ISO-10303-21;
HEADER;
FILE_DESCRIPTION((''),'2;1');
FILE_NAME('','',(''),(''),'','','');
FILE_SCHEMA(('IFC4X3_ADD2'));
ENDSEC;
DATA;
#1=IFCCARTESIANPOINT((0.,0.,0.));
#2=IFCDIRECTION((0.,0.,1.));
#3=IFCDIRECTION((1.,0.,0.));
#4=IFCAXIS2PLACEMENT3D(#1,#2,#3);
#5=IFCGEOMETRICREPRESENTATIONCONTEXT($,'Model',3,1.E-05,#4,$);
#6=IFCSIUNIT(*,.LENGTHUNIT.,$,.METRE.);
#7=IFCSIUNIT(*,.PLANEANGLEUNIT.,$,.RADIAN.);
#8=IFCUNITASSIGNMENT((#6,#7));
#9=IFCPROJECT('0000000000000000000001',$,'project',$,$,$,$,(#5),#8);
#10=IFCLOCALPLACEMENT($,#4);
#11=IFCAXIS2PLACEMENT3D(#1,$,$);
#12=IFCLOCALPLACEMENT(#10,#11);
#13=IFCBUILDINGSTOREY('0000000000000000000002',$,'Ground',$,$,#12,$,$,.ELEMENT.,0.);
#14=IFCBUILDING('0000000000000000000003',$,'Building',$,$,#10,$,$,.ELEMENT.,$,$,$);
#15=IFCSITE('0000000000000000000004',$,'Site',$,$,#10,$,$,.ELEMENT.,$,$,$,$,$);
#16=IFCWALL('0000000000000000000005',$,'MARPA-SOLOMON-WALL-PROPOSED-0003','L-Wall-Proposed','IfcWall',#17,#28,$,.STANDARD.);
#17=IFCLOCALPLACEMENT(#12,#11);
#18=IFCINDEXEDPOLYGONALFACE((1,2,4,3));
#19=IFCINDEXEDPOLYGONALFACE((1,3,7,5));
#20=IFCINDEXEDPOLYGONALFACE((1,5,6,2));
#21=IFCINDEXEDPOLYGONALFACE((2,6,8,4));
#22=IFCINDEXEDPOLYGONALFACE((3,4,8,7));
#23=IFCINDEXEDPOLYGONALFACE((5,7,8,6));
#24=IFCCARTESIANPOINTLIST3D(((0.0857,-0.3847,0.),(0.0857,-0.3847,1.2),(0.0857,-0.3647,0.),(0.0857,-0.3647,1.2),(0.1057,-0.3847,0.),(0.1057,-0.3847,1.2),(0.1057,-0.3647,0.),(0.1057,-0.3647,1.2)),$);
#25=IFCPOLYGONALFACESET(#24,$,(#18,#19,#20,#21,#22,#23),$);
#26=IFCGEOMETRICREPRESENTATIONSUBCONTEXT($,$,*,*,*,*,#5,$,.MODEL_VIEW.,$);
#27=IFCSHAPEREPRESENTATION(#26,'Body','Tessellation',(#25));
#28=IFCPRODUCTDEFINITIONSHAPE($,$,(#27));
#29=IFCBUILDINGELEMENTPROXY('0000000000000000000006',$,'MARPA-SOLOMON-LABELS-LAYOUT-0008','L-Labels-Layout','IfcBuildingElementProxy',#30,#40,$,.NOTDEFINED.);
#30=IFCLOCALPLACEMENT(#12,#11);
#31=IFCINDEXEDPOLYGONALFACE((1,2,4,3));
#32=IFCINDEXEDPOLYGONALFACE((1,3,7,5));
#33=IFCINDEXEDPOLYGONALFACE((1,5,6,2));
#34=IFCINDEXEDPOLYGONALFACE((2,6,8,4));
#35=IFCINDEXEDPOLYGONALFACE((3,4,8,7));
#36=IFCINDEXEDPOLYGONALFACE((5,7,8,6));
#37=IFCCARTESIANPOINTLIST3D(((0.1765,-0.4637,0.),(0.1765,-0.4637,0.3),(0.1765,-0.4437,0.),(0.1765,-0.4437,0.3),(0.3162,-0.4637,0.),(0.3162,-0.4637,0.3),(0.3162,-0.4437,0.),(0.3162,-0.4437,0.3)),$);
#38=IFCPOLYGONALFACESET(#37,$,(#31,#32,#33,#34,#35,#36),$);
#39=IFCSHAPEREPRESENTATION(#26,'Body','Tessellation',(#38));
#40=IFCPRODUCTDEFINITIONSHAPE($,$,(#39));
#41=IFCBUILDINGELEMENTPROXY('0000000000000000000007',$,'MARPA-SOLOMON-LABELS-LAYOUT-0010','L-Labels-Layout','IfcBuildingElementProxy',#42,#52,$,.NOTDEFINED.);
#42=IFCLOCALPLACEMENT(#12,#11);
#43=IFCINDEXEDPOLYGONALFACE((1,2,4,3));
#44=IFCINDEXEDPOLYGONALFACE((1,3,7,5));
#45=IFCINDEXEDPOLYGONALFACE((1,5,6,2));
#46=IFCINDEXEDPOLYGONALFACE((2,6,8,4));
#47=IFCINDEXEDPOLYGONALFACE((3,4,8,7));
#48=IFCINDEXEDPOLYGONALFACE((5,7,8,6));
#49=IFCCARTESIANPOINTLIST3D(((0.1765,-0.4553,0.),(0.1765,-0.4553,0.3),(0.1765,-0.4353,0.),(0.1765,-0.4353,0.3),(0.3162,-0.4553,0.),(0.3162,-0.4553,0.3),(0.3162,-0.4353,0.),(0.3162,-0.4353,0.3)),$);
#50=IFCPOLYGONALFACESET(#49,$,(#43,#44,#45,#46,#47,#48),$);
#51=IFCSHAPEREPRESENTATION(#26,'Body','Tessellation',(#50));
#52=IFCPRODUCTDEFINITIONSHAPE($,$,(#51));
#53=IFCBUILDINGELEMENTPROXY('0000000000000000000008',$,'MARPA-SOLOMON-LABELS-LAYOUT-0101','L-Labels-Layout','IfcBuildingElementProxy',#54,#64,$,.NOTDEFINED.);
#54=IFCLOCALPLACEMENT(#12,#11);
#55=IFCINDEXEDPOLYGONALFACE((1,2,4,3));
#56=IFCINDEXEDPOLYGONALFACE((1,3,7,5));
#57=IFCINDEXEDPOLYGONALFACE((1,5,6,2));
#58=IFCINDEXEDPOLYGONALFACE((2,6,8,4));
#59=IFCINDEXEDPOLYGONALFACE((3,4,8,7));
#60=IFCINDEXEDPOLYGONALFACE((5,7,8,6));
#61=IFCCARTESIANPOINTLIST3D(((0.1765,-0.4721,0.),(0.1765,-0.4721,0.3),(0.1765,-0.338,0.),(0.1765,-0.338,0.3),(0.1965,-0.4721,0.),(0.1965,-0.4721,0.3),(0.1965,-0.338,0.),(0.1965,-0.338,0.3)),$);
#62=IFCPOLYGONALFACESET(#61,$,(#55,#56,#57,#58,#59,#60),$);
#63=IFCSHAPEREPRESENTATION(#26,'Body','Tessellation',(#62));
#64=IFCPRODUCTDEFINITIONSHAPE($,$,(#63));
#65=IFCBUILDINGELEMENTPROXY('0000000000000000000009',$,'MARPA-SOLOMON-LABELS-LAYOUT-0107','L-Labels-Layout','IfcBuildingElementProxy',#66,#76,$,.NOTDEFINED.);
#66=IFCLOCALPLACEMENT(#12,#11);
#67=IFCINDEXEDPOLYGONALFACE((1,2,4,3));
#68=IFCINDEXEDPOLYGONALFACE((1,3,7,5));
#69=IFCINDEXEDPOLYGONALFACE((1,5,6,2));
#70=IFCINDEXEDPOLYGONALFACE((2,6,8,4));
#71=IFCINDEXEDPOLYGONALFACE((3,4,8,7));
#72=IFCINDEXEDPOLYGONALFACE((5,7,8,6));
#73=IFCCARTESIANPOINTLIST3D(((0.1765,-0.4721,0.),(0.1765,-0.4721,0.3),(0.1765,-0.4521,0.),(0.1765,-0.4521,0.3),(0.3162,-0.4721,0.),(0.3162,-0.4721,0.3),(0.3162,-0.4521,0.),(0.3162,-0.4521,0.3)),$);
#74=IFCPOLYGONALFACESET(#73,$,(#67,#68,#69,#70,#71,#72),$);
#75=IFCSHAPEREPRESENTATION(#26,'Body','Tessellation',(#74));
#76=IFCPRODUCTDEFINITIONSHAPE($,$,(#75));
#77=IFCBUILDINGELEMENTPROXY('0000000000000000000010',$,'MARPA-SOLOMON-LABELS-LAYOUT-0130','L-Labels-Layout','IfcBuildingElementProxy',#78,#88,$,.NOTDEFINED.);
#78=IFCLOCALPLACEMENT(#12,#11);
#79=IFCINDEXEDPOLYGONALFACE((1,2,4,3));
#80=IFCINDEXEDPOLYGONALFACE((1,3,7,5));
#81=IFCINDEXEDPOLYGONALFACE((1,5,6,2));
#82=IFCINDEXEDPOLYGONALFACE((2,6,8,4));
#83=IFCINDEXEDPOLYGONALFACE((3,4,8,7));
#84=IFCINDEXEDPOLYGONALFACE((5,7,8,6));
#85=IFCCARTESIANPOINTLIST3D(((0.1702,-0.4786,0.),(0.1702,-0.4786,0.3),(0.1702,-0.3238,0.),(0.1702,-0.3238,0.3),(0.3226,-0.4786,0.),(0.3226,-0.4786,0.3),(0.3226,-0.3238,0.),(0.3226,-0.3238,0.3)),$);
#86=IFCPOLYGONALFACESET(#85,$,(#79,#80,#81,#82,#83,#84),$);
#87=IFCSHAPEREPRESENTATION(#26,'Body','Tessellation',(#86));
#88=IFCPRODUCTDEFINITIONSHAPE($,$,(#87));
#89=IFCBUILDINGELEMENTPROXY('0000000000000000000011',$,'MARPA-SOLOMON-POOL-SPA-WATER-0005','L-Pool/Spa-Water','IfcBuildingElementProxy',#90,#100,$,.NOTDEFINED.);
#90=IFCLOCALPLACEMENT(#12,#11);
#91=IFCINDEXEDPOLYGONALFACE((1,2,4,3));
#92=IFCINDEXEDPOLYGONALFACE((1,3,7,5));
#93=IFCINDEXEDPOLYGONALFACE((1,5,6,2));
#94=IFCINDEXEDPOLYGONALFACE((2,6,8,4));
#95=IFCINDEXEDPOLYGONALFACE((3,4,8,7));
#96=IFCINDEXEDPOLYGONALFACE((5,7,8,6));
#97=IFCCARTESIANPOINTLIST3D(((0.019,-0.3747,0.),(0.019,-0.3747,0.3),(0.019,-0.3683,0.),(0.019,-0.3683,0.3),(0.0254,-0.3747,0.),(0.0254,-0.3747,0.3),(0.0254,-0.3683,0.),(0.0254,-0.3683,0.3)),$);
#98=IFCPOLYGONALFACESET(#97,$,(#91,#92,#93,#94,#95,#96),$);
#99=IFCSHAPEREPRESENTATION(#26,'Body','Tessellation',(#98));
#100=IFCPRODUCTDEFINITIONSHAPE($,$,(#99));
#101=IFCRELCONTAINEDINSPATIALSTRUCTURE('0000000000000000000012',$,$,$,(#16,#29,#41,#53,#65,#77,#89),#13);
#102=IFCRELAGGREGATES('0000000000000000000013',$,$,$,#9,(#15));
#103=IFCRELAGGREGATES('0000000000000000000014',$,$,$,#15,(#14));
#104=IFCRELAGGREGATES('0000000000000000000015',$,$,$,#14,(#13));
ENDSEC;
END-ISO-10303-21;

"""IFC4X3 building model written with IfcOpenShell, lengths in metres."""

from ifc_helpers import new_model, si_unit, frame, frame_2d, origin, origin_with_axes, place, context, subcontext, project, spatial, polyline, rectangle, outline, extrude, element, save


model = new_model("IFC4X3")

# Units and contexts
model_context = context("Model", 3, precision=1e-05, world=origin_with_axes())
sub_context = subcontext(model_context, None, None, "MODEL_VIEW")
ifc_project = project(units=[si_unit("LENGTHUNIT", "METRE"), si_unit("PLANEANGLEUNIT", "RADIAN")], contexts=[model_context])

# Site, building, storey
placement = place(None, origin_with_axes())
site = spatial("IfcSite", under=ifc_project, at=placement, Name="Site", CompositionType="ELEMENT")
building = spatial("IfcBuilding", under=site, at=placement, Name="Building", CompositionType="ELEMENT")
storey_placement = place(placement, origin())
storey = spatial("IfcBuildingStorey", under=building, at=storey_placement, Name="Ground", CompositionType="ELEMENT", Elevation=0.0)

# Wall
for number, where, x_axis, name in (
    (1, (0.0857, -0.3747, 0.0), (1.0, 0.0, 0.0), "MARPA-SOLOMON-WALL-PROPOSED-0003"),
):
    element("IfcWall", number, at=place(storey_placement, frame(where, x_axis=x_axis)), inside=storey, Name=name, Description="L-Wall-Proposed", ObjectType="IfcWall", PredefinedType="STANDARD", context=sub_context, shape_type="SweptSolid", body=[
        extrude(rectangle(XDim=0.02, YDim=0.02, at=frame_2d((0.01, 0.0))), origin(), (0.0, 0.0, 1.0), 1.2),
    ])

# Building element proxies
for number, where, name in (
    (2, (0.1765, -0.4637, 0.0), "MARPA-SOLOMON-LABELS-LAYOUT-0008"),
    (3, (0.1765, -0.4553, 0.0), "MARPA-SOLOMON-LABELS-LAYOUT-0010"),
):
    element("IfcBuildingElementProxy", number, at=place(placement, frame(where)), inside=storey, Name=name, Description="L-Labels-Layout", ObjectType="IfcBuildingElementProxy", PredefinedType="NOTDEFINED", context=sub_context, shape_type="SweptSolid", body=[
        extrude(rectangle(XDim=0.1397, YDim=0.02, at=frame_2d((0.0699, 0.01))), origin(), (0.0, 0.0, 1.0), 0.3),
    ])
proxy_1_placement = place(placement, frame((0.1765, -0.4721, 0.0)))
element("IfcBuildingElementProxy", 4, at=proxy_1_placement, inside=storey, Name="MARPA-SOLOMON-LABELS-LAYOUT-0101", Description="L-Labels-Layout", ObjectType="IfcBuildingElementProxy", PredefinedType="NOTDEFINED", context=sub_context, shape_type="SweptSolid", body=[
    extrude(rectangle(XDim=0.02, YDim=0.1341, at=frame_2d((0.01, 0.0671))), origin(), (0.0, 0.0, 1.0), 0.3),
])
for number, where, name in (
    (5, (0.1765, -0.4721, 0.0), "MARPA-SOLOMON-LABELS-LAYOUT-0107"),
):
    element("IfcBuildingElementProxy", number, at=place(placement, frame(where)), inside=storey, Name=name, Description="L-Labels-Layout", ObjectType="IfcBuildingElementProxy", PredefinedType="NOTDEFINED", context=sub_context, shape_type="SweptSolid", body=[
        extrude(rectangle(XDim=0.1397, YDim=0.02, at=frame_2d((0.0699, 0.01))), origin(), (0.0, 0.0, 1.0), 0.3),
    ])
for number, where, name in (
    (6, (0.1702, -0.4786, 0.0), "MARPA-SOLOMON-LABELS-LAYOUT-0130"),
):
    element("IfcBuildingElementProxy", number, at=place(placement, frame(where)), inside=storey, Name=name, Description="L-Labels-Layout", ObjectType="IfcBuildingElementProxy", PredefinedType="NOTDEFINED", context=sub_context, shape_type="SweptSolid", body=[
        extrude(outline(polyline([(0.0, 0.1548), (0.1524, 0.1548), (0.1524, 0.0), (0.0, 0.0), (0.0, 0.1548)])), origin(), (0.0, 0.0, 1.0), 0.3),
    ])
for number, where, name in (
    (7, (0.019, -0.3747, 0.0), "MARPA-SOLOMON-POOL-SPA-WATER-0005"),
):
    element("IfcBuildingElementProxy", number, at=place(placement, frame(where)), inside=storey, Name=name, Description="L-Pool/Spa-Water", ObjectType="IfcBuildingElementProxy", PredefinedType="NOTDEFINED", context=sub_context, shape_type="SweptSolid", body=[
        extrude(outline(polyline([(0.0, 0.0064), (0.0063, 0.0064), (0.0063, 0.0), (0.0, 0.0), (0.0, 0.0064)])), origin(), (0.0, 0.0, 1.0), 0.3),
    ])

save(model, "model.ifc")
